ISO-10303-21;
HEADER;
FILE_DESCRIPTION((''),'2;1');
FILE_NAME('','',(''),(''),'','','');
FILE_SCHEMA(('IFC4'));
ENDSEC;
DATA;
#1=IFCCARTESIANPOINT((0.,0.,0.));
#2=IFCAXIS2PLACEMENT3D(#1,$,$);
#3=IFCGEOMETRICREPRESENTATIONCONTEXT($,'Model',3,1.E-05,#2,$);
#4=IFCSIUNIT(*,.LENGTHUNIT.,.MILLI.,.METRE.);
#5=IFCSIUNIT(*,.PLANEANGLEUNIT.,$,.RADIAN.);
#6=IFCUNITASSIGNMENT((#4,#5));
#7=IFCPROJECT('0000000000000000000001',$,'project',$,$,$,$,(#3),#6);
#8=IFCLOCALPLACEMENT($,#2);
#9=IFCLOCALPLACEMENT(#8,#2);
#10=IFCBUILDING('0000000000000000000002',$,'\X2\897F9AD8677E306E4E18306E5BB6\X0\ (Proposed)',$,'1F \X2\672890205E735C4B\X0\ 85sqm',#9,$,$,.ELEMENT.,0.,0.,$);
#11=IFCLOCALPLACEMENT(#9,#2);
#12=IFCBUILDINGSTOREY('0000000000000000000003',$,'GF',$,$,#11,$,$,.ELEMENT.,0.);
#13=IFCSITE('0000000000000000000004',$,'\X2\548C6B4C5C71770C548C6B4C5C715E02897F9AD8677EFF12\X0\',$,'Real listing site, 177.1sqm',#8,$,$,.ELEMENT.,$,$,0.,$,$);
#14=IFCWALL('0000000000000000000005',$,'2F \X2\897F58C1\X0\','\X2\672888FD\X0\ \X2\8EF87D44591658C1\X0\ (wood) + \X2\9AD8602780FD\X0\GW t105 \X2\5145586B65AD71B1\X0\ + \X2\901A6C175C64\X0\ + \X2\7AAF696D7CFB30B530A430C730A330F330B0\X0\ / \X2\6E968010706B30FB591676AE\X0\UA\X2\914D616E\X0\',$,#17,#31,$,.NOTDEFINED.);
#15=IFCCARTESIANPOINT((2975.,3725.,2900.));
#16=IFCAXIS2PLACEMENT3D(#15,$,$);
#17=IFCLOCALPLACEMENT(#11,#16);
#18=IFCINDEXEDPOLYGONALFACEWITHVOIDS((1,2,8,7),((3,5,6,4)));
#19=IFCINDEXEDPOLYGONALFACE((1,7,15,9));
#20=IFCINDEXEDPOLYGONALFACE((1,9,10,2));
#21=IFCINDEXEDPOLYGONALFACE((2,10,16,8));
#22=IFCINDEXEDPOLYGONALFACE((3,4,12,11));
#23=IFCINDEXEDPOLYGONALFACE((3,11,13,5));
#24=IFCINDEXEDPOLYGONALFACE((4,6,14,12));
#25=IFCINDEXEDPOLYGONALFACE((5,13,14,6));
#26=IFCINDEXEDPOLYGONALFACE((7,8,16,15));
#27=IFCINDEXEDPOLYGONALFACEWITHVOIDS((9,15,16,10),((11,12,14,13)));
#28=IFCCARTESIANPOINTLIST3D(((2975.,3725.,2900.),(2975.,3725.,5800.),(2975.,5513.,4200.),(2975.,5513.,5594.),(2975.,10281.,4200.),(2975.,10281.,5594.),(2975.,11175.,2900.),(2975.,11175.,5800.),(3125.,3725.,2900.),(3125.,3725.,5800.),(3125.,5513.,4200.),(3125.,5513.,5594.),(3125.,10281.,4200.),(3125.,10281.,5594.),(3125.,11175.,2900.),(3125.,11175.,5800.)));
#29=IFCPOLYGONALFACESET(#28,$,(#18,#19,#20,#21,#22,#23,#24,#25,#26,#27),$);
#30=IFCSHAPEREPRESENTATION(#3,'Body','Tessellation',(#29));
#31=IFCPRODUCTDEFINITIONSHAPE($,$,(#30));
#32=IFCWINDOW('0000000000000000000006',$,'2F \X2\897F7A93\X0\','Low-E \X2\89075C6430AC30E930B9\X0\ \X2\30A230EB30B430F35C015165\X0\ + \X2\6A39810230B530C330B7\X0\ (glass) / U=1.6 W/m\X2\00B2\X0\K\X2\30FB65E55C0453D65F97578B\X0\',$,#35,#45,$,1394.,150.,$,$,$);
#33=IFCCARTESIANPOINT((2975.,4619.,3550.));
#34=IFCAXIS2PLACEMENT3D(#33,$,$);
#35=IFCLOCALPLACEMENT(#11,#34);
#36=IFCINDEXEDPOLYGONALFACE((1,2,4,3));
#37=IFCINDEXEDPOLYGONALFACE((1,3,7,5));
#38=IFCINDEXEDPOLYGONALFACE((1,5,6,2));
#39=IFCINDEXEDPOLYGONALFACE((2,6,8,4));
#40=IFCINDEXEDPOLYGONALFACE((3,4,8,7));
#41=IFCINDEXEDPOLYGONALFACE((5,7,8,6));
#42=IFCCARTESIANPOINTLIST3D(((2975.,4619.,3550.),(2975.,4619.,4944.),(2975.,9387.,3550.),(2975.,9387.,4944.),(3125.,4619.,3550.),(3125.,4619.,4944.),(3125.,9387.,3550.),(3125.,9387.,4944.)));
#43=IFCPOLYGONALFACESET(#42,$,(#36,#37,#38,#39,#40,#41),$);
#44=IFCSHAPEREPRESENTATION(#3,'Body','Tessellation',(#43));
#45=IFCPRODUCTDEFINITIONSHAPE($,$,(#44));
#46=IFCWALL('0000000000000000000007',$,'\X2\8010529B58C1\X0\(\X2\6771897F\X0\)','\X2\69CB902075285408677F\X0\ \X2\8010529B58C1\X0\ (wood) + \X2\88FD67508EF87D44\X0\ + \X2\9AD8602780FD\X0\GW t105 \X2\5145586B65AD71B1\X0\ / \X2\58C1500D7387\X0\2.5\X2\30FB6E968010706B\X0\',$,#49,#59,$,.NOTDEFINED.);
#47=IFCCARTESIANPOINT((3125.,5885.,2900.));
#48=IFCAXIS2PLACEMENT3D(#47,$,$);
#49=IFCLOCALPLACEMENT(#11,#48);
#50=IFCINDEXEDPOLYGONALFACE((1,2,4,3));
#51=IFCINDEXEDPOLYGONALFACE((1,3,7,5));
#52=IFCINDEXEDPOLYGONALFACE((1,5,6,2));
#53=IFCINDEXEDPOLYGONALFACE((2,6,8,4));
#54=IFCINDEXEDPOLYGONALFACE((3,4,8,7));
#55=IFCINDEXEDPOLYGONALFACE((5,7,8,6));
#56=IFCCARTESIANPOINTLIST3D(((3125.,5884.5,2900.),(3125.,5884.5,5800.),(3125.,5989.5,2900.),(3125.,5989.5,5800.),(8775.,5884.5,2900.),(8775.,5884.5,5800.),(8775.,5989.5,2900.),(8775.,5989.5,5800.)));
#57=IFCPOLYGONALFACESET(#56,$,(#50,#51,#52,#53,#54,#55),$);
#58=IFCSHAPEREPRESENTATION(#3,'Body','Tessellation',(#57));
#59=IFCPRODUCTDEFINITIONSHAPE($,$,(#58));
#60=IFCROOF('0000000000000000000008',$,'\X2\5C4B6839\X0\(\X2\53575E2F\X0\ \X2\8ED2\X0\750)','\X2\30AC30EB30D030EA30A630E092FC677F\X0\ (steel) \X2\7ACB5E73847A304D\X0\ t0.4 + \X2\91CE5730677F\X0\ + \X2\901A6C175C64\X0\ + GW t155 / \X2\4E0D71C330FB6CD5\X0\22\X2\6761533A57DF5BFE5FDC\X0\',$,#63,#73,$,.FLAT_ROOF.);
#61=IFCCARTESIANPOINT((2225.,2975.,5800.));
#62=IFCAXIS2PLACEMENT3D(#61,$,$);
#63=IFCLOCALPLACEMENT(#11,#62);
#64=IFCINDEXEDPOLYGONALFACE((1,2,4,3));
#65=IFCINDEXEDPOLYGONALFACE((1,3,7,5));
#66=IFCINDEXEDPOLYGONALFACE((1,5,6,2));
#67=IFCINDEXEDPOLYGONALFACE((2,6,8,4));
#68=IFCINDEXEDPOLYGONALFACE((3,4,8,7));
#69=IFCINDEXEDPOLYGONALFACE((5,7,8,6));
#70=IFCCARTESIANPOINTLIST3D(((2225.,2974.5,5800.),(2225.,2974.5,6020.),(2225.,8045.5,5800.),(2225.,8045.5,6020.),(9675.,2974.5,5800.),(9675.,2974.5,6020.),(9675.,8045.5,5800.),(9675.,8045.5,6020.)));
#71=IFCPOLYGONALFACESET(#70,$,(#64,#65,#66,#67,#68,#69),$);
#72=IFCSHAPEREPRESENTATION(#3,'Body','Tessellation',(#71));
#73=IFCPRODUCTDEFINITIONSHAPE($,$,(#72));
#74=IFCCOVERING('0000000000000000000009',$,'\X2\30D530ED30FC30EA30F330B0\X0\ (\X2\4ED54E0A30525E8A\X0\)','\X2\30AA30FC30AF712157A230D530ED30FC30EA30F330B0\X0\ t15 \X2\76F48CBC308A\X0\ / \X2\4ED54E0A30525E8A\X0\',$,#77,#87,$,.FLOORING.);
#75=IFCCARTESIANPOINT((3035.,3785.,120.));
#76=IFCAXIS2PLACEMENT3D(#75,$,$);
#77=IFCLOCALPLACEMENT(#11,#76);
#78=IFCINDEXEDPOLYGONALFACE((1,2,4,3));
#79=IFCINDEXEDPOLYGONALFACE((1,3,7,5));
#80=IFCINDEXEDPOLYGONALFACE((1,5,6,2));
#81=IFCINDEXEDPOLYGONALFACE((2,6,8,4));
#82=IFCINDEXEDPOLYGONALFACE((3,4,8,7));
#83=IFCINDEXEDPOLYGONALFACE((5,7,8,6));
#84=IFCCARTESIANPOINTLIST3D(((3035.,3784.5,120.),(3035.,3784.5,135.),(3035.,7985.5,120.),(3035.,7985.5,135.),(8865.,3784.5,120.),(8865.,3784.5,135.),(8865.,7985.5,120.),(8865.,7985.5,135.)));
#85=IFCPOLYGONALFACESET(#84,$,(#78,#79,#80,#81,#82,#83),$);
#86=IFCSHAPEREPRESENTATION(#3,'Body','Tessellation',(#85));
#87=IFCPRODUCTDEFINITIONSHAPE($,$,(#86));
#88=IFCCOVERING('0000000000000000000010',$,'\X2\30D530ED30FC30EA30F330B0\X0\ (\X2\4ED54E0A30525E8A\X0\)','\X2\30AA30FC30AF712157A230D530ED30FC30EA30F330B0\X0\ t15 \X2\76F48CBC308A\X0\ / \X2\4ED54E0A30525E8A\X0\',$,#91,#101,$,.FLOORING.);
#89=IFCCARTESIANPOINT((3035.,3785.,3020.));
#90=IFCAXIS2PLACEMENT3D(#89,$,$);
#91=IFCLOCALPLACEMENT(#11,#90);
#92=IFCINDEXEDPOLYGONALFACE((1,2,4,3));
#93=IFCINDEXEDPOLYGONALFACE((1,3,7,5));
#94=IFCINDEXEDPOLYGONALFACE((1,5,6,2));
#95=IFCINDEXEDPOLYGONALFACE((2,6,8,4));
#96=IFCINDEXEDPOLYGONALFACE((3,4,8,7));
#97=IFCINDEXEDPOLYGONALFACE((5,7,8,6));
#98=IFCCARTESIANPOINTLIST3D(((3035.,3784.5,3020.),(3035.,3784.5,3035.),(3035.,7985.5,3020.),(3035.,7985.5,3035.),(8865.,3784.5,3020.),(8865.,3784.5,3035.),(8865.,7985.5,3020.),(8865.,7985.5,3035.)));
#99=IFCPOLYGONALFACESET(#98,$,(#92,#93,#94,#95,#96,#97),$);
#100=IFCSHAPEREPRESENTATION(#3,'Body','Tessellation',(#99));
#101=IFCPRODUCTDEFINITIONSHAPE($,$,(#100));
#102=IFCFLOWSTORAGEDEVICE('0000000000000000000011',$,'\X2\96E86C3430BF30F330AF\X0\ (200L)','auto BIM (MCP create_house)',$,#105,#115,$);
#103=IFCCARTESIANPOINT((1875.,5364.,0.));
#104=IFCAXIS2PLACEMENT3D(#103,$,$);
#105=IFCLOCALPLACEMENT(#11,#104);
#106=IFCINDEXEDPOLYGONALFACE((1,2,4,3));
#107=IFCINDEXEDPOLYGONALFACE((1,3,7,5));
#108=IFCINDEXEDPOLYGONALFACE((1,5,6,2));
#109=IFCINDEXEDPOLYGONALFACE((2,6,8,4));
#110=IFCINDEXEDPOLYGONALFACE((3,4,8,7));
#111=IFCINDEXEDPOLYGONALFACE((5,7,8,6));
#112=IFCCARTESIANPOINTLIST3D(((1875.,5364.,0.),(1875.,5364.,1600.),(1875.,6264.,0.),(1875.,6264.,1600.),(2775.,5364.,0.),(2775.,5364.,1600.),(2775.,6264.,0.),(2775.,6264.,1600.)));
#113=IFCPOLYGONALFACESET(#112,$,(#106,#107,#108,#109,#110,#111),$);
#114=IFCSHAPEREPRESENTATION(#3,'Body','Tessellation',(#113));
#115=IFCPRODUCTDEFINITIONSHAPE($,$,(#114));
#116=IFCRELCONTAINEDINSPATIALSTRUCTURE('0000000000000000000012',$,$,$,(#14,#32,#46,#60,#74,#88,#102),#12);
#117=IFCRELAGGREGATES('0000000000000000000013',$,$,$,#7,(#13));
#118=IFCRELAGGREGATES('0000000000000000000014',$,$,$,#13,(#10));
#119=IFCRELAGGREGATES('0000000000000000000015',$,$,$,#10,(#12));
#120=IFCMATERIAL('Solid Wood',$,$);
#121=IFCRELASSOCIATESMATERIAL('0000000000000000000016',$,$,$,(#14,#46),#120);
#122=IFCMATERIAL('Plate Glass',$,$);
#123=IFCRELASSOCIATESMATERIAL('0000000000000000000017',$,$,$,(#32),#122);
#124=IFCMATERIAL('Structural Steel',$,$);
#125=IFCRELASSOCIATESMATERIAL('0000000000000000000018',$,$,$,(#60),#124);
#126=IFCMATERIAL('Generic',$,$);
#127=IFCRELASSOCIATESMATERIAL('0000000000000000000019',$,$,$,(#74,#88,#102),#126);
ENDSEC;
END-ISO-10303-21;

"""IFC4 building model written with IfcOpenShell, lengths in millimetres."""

from ifc_helpers import new_model, si_unit, frame, frame_2d, origin, place, context, project, spatial, rectangle, extrude, material, element, fill, save


model = new_model("IFC4")

# Units and contexts
model_context = context("Model", 3, precision=1e-05, world=origin())
ifc_project = project(units=[si_unit("LENGTHUNIT", "METRE", prefix="MILLI"), si_unit("PLANEANGLEUNIT", "RADIAN")], contexts=[model_context])

# Site, building, storey
site_placement = place(None, origin())
site = spatial("IfcSite", under=ifc_project, at=site_placement, Name="和歌山県和歌山市西高松２", ObjectType="Real listing site, 177.1sqm", CompositionType="ELEMENT", RefElevation=0.0)
building_placement = place(site_placement, origin())
building = spatial("IfcBuilding", under=site, at=building_placement, Name="西高松の丘の家 (Proposed)", ObjectType="1F 木造平屋 85sqm", CompositionType="ELEMENT", ElevationOfRefHeight=0.0, ElevationOfTerrain=0.0)
storey_placement = place(building_placement, origin())
storey = spatial("IfcBuildingStorey", under=building, at=storey_placement, Name="GF", CompositionType="ELEMENT", Elevation=0.0)

# Shared definitions
ifc_material_1 = material(Name="Solid Wood")
ifc_material_2 = material(Name="Generic")

# Shared definitions
ifc_material_3 = material(Name="Plate Glass")

# Wall, opening, window
wall_1_placement = place(storey_placement, frame((2975.0, 3725.0, 2900.0)))
wall_1 = element("IfcWall", 1, at=wall_1_placement, inside=storey, material=ifc_material_1, Name="2F 西壁", Description="木製 軸組外壁 (wood) + 高性能GW t105 充填断熱 + 通気層 + 窯業系サイディング / 準耐火・外皮UA配慮", PredefinedType="NOTDEFINED", context=model_context, shape_type="SweptSolid", body=[
    extrude(rectangle(XDim=150.0, YDim=7450.0, at=frame_2d((75.0, 3725.0))), frame((2975.0, 3725.0, 2900.0)), (0.0, 0.0, 1.0), 2900.0),
])
opening_1_placement = place(storey_placement, frame((2975.0, 4619.0, 3550.0)))
opening_1 = element("IfcOpeningElement", 2, at=opening_1_placement, cuts=wall_1, PredefinedType="NOTDEFINED", context=model_context, shape_type="SweptSolid", body=[
    extrude(rectangle(XDim=150.0, YDim=4768.0, at=frame_2d((75.0, 2384.0))), frame((2975.0, 4619.0, 3550.0)), (0.0, 0.0, 1.0), 1394.0),
])
window_1_placement = place(storey_placement, frame((2975.0, 4619.0, 3550.0)))
window_1 = element("IfcWindow", 3, at=window_1_placement, inside=storey, material=ifc_material_3, Name="2F 西窓", Description="Low-E 複層ガラス アルゴン封入 + 樹脂サッシ (glass) / U=1.6 W/m²K・日射取得型", OverallHeight=1394.0, OverallWidth=150.0, context=model_context, shape_type="SweptSolid", body=[
    extrude(rectangle(XDim=150.0, YDim=4768.0, at=frame_2d((75.0, 2384.0))), frame((2975.0, 4619.0, 3550.0)), (0.0, 0.0, 1.0), 1394.0),
])
fill(opening_1, window_1)

# Wall
wall_2_placement = place(storey_placement, frame((3125.0, 5885.0, 2900.0)))
element("IfcWall", 4, at=wall_2_placement, inside=storey, material=ifc_material_1, Name="耐力壁(東西)", Description="構造用合板 耐力壁 (wood) + 製材軸組 + 高性能GW t105 充填断熱 / 壁倍率2.5・準耐火", PredefinedType="NOTDEFINED", context=model_context, shape_type="SweptSolid", body=[
    extrude(rectangle(XDim=5650.0, YDim=105.0, at=frame_2d((2825.0, 52.0))), frame((3125.0, 5885.0, 2900.0)), (0.0, 0.0, 1.0), 2900.0),
])

# Roof
ifc_material_4 = material(Name="Structural Steel")
for number, where, name in (
    (5, (2225.0, 2975.0, 5800.0), "屋根(南帯 軒750)"),
):
    element("IfcRoof", number, at=place(storey_placement, frame(where)), inside=storey, material=ifc_material_4, Name=name, Description="ガルバリウム鋼板 (steel) 立平葺き t0.4 + 野地板 + 通気層 + GW t155 / 不燃・法22条区域対応", PredefinedType="FLAT_ROOF", context=model_context, shape_type="SweptSolid", body=[
        extrude(rectangle(XDim=7450.0, YDim=5071.0, at=frame_2d((3725.0, 2535.0))), frame((2225.0, 2975.0, 5800.0)), (0.0, 0.0, 1.0), 220.0),
    ])

# Coverings
covering_1_placement = place(storey_placement, frame((3035.0, 3785.0, 120.0)))
element("IfcCovering", 6, at=covering_1_placement, inside=storey, material=ifc_material_2, Name="フローリング (仕上げ床)", Description="オーク無垢フローリング t15 直貼り / 仕上げ床", PredefinedType="FLOORING", context=model_context, shape_type="SweptSolid", body=[
    extrude(rectangle(XDim=5830.0, YDim=4201.0, at=frame_2d((2915.0, 2100.0))), frame((3035.0, 3785.0, 120.0)), (0.0, 0.0, 1.0), 15.0),
])
covering_2_placement = place(storey_placement, frame((3035.0, 3785.0, 3020.0)))
element("IfcCovering", 7, at=covering_2_placement, inside=storey, material=ifc_material_2, Name="フローリング (仕上げ床)", Description="オーク無垢フローリング t15 直貼り / 仕上げ床", PredefinedType="FLOORING", context=model_context, shape_type="SweptSolid", body=[
    extrude(rectangle(XDim=5830.0, YDim=4201.0, at=frame_2d((2915.0, 2100.0))), frame((3035.0, 3785.0, 3020.0)), (0.0, 0.0, 1.0), 15.0),
])

# Flow storage device
flow_storage_device_placement = place(storey_placement, frame((1875.0, 5364.0, 0.0)))
element("IfcFlowStorageDevice", 8, at=flow_storage_device_placement, inside=storey, material=ifc_material_2, Name="雨水タンク (200L)", Description="auto BIM (MCP create_house)", context=model_context, shape_type="SweptSolid", body=[
    extrude(rectangle(XDim=900.0, YDim=900.0, at=frame_2d((450.0, 450.0))), frame((1875.0, 5364.0, 0.0)), (0.0, 0.0, 1.0), 1600.0),
])

save(model, "model.ifc")
